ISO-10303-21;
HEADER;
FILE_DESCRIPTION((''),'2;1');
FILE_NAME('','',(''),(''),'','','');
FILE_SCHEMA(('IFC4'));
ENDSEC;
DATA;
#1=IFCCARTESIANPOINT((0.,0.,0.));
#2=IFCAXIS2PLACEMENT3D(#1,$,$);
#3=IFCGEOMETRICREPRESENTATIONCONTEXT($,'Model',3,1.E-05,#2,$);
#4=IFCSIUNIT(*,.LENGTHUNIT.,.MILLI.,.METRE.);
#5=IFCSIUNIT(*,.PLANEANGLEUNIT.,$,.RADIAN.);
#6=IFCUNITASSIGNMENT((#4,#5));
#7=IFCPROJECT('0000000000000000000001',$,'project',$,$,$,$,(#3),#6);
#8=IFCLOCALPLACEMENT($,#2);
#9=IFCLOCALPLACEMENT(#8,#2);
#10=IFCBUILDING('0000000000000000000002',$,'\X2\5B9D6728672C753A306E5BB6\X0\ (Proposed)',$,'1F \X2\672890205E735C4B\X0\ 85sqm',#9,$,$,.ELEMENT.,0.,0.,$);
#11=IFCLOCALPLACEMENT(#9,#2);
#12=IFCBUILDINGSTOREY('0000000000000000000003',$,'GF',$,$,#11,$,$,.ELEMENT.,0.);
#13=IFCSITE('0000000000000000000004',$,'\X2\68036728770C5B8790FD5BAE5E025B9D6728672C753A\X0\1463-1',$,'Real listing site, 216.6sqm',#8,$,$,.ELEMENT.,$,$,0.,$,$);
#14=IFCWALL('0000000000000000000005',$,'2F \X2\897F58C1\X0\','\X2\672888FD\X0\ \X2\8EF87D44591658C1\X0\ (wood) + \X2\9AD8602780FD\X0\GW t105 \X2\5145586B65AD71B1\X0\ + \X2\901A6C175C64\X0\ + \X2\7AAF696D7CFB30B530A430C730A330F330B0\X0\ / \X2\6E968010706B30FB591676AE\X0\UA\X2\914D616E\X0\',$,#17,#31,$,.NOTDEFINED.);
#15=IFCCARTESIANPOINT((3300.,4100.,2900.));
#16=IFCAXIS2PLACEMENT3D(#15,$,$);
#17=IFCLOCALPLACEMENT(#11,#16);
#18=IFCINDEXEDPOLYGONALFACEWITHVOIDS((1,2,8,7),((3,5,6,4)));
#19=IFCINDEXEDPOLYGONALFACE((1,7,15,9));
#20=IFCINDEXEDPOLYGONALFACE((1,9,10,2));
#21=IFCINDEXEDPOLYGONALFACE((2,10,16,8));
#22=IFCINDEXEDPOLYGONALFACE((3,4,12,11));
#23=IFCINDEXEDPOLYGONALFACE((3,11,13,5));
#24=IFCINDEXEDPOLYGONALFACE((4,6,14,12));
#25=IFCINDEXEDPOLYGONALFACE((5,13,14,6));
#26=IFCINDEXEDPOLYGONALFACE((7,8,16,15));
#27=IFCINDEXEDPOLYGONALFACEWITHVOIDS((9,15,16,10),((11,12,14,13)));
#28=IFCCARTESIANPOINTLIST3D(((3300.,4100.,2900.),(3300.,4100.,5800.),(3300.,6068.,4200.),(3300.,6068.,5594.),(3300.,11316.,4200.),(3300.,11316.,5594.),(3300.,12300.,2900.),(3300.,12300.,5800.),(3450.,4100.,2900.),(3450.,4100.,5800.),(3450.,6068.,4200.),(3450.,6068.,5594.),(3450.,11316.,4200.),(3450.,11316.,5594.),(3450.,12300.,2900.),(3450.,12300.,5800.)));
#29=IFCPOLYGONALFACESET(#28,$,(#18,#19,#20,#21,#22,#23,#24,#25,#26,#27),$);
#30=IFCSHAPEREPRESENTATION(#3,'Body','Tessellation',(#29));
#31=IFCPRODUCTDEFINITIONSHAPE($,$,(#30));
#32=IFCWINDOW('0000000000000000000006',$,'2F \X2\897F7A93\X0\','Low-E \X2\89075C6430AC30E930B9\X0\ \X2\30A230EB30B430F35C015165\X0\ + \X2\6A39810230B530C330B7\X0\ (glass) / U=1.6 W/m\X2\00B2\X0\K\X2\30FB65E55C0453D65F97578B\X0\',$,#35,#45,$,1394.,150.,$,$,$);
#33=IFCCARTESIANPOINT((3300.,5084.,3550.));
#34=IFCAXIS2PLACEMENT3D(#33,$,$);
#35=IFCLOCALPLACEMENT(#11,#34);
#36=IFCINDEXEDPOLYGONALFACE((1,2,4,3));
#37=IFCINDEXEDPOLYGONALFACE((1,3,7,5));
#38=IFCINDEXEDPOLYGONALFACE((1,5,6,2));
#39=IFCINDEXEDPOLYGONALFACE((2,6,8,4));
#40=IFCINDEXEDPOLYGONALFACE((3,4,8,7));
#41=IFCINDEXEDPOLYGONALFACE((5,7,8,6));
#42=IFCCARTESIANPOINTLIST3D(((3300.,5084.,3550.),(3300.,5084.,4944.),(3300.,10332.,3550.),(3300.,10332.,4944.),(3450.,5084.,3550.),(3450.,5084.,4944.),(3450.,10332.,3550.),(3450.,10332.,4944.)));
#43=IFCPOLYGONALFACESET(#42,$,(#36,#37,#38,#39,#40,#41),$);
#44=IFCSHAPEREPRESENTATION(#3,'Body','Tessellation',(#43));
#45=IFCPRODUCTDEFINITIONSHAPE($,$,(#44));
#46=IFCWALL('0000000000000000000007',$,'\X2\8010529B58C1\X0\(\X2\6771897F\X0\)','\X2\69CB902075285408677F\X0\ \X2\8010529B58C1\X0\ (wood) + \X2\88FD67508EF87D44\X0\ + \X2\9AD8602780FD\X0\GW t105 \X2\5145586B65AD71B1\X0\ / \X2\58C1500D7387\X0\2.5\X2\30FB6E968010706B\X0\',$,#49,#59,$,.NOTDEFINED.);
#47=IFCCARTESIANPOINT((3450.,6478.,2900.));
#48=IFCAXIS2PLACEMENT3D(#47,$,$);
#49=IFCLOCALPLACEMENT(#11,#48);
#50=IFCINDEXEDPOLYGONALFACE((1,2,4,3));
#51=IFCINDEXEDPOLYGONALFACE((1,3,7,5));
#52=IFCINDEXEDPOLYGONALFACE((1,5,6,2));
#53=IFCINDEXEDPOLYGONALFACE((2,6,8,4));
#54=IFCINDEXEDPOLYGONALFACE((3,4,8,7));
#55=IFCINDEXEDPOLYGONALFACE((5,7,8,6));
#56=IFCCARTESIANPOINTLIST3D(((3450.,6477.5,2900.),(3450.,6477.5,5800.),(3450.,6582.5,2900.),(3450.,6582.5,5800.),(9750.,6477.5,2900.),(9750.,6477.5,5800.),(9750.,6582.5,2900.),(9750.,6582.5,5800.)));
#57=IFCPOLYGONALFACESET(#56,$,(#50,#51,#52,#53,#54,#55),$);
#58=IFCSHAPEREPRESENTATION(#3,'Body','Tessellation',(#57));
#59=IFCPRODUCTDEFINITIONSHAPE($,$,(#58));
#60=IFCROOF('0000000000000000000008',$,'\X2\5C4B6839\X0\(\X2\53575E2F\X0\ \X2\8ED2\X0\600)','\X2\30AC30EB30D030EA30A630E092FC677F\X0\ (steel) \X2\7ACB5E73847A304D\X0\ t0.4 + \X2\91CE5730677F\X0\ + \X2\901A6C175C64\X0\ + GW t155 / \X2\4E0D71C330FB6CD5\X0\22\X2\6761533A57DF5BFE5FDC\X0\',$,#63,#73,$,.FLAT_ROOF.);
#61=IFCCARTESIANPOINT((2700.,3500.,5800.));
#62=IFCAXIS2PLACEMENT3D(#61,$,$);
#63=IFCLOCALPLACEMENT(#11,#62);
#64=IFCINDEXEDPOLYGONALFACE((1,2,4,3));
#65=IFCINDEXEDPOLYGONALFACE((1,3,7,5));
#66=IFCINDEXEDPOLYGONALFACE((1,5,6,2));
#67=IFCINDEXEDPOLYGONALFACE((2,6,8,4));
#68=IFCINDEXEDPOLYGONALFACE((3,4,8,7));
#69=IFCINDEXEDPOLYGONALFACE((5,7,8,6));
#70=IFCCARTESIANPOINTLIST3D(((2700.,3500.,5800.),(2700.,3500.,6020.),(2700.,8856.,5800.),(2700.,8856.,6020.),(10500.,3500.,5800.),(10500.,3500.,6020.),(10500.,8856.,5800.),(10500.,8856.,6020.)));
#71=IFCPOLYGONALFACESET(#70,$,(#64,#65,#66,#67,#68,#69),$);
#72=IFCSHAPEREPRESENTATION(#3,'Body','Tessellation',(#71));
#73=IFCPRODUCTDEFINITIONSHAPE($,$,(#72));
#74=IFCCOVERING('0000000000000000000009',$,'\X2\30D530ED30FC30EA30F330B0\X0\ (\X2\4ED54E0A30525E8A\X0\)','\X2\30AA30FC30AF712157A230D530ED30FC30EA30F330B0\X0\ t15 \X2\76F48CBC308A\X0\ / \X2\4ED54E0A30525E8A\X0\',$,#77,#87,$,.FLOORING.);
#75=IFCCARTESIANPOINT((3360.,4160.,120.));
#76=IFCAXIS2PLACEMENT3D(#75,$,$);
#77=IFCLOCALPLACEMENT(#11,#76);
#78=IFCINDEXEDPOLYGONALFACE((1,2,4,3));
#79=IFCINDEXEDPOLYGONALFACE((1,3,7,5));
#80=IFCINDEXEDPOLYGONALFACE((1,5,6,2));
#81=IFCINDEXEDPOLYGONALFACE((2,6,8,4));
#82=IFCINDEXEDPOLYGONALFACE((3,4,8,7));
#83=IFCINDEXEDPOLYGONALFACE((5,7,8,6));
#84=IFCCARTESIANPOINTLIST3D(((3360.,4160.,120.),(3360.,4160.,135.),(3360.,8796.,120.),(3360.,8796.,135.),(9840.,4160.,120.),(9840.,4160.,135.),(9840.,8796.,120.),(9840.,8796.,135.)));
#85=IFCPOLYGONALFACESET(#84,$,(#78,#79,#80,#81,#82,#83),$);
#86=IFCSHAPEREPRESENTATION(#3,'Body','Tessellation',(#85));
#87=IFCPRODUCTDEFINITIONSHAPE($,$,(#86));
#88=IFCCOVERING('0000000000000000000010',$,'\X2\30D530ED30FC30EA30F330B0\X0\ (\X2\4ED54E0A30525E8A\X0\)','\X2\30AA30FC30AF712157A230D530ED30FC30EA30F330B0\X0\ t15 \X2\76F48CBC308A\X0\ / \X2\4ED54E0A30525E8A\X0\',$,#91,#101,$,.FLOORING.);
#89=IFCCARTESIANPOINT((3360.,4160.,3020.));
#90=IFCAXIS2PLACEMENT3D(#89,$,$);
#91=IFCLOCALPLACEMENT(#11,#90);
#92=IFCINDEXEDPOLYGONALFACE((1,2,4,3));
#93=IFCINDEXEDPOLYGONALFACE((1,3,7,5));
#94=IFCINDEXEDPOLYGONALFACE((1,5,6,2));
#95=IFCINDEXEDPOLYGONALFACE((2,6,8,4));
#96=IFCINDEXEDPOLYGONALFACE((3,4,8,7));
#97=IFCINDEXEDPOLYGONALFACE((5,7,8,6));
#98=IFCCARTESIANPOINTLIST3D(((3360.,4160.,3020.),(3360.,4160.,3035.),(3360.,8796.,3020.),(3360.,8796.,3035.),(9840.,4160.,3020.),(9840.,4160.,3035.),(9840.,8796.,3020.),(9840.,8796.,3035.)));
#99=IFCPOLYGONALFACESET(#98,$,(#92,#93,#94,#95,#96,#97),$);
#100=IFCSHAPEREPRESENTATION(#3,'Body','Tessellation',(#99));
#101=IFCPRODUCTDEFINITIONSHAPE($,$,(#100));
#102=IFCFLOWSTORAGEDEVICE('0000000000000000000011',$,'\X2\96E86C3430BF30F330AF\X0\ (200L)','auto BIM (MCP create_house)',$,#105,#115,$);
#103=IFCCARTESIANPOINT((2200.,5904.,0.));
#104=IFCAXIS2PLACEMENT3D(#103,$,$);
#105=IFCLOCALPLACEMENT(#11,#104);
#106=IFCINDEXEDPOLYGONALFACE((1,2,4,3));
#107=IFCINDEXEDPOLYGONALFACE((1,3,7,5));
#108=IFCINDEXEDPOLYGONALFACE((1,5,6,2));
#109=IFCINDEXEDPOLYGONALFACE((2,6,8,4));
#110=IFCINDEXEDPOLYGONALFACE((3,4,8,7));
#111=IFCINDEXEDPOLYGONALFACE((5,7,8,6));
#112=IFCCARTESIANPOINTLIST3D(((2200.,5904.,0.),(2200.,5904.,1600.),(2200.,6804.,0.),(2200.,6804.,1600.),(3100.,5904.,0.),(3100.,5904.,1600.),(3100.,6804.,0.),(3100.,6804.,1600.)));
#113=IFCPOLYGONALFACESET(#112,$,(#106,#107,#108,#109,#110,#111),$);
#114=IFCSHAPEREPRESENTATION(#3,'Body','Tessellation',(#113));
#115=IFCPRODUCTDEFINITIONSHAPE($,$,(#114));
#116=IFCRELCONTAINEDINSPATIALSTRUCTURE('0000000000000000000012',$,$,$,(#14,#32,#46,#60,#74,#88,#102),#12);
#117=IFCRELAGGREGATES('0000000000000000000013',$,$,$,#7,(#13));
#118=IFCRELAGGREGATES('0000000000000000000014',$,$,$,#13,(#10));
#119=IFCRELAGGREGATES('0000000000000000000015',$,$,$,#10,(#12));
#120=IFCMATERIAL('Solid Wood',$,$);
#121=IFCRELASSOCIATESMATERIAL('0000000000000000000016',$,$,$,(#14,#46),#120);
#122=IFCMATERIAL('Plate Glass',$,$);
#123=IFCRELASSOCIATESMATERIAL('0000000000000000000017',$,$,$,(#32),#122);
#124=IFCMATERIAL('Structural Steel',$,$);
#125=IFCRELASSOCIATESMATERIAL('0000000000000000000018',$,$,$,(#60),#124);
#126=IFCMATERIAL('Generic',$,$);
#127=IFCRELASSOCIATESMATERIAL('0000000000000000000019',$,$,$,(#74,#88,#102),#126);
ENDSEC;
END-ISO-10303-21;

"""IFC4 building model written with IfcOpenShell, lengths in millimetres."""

from ifc_helpers import new_model, si_unit, frame, frame_2d, origin, place, context, project, spatial, rectangle, extrude, material, element, fill, save


model = new_model("IFC4")

# Units and contexts
model_context = context("Model", 3, precision=1e-05, world=origin())
ifc_project = project(units=[si_unit("LENGTHUNIT", "METRE", prefix="MILLI"), si_unit("PLANEANGLEUNIT", "RADIAN")], contexts=[model_context])

# Site, building, storey
site_placement = place(None, origin())
site = spatial("IfcSite", under=ifc_project, at=site_placement, Name="栃木県宇都宮市宝木本町1463-1", ObjectType="Real listing site, 216.6sqm", CompositionType="ELEMENT", RefElevation=0.0)
building_placement = place(site_placement, origin())
building = spatial("IfcBuilding", under=site, at=building_placement, Name="宝木本町の家 (Proposed)", ObjectType="1F 木造平屋 85sqm", CompositionType="ELEMENT", ElevationOfRefHeight=0.0, ElevationOfTerrain=0.0)
storey_placement = place(building_placement, origin())
storey = spatial("IfcBuildingStorey", under=building, at=storey_placement, Name="GF", CompositionType="ELEMENT", Elevation=0.0)

# Shared definitions
ifc_material_1 = material(Name="Solid Wood")
ifc_material_2 = material(Name="Generic")

# Shared definitions
ifc_material_3 = material(Name="Plate Glass")

# Wall, opening, window
wall_1_placement = place(storey_placement, frame((3300.0, 4100.0, 2900.0)))
wall_1 = element("IfcWall", 1, at=wall_1_placement, inside=storey, material=ifc_material_1, Name="2F 西壁", Description="木製 軸組外壁 (wood) + 高性能GW t105 充填断熱 + 通気層 + 窯業系サイディング / 準耐火・外皮UA配慮", PredefinedType="NOTDEFINED", context=model_context, shape_type="SweptSolid", body=[
    extrude(rectangle(XDim=150.0, YDim=8200.0, at=frame_2d((75.0, 4100.0))), frame((3300.0, 4100.0, 2900.0)), (0.0, 0.0, 1.0), 2900.0),
])
opening_1_placement = place(storey_placement, frame((3300.0, 5084.0, 3550.0)))
opening_1 = element("IfcOpeningElement", 2, at=opening_1_placement, cuts=wall_1, PredefinedType="NOTDEFINED", context=model_context, shape_type="SweptSolid", body=[
    extrude(rectangle(XDim=150.0, YDim=5248.0, at=frame_2d((75.0, 2624.0))), frame((3300.0, 5084.0, 3550.0)), (0.0, 0.0, 1.0), 1394.0),
])
window_1_placement = place(storey_placement, frame((3300.0, 5084.0, 3550.0)))
window_1 = element("IfcWindow", 3, at=window_1_placement, inside=storey, material=ifc_material_3, Name="2F 西窓", Description="Low-E 複層ガラス アルゴン封入 + 樹脂サッシ (glass) / U=1.6 W/m²K・日射取得型", OverallHeight=1394.0, OverallWidth=150.0, context=model_context, shape_type="SweptSolid", body=[
    extrude(rectangle(XDim=150.0, YDim=5248.0, at=frame_2d((75.0, 2624.0))), frame((3300.0, 5084.0, 3550.0)), (0.0, 0.0, 1.0), 1394.0),
])
fill(opening_1, window_1)

# Wall
wall_2_placement = place(storey_placement, frame((3450.0, 6478.0, 2900.0)))
element("IfcWall", 4, at=wall_2_placement, inside=storey, material=ifc_material_1, Name="耐力壁(東西)", Description="構造用合板 耐力壁 (wood) + 製材軸組 + 高性能GW t105 充填断熱 / 壁倍率2.5・準耐火", PredefinedType="NOTDEFINED", context=model_context, shape_type="SweptSolid", body=[
    extrude(rectangle(XDim=6300.0, YDim=105.0, at=frame_2d((3150.0, 52.0))), frame((3450.0, 6478.0, 2900.0)), (0.0, 0.0, 1.0), 2900.0),
])

# Roof
ifc_material_4 = material(Name="Structural Steel")
for number, where, name in (
    (5, (2700.0, 3500.0, 5800.0), "屋根(南帯 軒600)"),
):
    element("IfcRoof", number, at=place(storey_placement, frame(where)), inside=storey, material=ifc_material_4, Name=name, Description="ガルバリウム鋼板 (steel) 立平葺き t0.4 + 野地板 + 通気層 + GW t155 / 不燃・法22条区域対応", PredefinedType="FLAT_ROOF", context=model_context, shape_type="SweptSolid", body=[
        extrude(rectangle(XDim=7800.0, YDim=5356.0, at=frame_2d((3900.0, 2678.0))), frame((2700.0, 3500.0, 5800.0)), (0.0, 0.0, 1.0), 220.0),
    ])

# Coverings
covering_1_placement = place(storey_placement, frame((3360.0, 4160.0, 120.0)))
element("IfcCovering", 6, at=covering_1_placement, inside=storey, material=ifc_material_2, Name="フローリング (仕上げ床)", Description="オーク無垢フローリング t15 直貼り / 仕上げ床", PredefinedType="FLOORING", context=model_context, shape_type="SweptSolid", body=[
    extrude(rectangle(XDim=6480.0, YDim=4636.0, at=frame_2d((3240.0, 2318.0))), frame((3360.0, 4160.0, 120.0)), (0.0, 0.0, 1.0), 15.0),
])
covering_2_placement = place(storey_placement, frame((3360.0, 4160.0, 3020.0)))
element("IfcCovering", 7, at=covering_2_placement, inside=storey, material=ifc_material_2, Name="フローリング (仕上げ床)", Description="オーク無垢フローリング t15 直貼り / 仕上げ床", PredefinedType="FLOORING", context=model_context, shape_type="SweptSolid", body=[
    extrude(rectangle(XDim=6480.0, YDim=4636.0, at=frame_2d((3240.0, 2318.0))), frame((3360.0, 4160.0, 3020.0)), (0.0, 0.0, 1.0), 15.0),
])

# Flow storage device
flow_storage_device_placement = place(storey_placement, frame((2200.0, 5904.0, 0.0)))
element("IfcFlowStorageDevice", 8, at=flow_storage_device_placement, inside=storey, material=ifc_material_2, Name="雨水タンク (200L)", Description="auto BIM (MCP create_house)", context=model_context, shape_type="SweptSolid", body=[
    extrude(rectangle(XDim=900.0, YDim=900.0, at=frame_2d((450.0, 450.0))), frame((2200.0, 5904.0, 0.0)), (0.0, 0.0, 1.0), 1600.0),
])

save(model, "model.ifc")
